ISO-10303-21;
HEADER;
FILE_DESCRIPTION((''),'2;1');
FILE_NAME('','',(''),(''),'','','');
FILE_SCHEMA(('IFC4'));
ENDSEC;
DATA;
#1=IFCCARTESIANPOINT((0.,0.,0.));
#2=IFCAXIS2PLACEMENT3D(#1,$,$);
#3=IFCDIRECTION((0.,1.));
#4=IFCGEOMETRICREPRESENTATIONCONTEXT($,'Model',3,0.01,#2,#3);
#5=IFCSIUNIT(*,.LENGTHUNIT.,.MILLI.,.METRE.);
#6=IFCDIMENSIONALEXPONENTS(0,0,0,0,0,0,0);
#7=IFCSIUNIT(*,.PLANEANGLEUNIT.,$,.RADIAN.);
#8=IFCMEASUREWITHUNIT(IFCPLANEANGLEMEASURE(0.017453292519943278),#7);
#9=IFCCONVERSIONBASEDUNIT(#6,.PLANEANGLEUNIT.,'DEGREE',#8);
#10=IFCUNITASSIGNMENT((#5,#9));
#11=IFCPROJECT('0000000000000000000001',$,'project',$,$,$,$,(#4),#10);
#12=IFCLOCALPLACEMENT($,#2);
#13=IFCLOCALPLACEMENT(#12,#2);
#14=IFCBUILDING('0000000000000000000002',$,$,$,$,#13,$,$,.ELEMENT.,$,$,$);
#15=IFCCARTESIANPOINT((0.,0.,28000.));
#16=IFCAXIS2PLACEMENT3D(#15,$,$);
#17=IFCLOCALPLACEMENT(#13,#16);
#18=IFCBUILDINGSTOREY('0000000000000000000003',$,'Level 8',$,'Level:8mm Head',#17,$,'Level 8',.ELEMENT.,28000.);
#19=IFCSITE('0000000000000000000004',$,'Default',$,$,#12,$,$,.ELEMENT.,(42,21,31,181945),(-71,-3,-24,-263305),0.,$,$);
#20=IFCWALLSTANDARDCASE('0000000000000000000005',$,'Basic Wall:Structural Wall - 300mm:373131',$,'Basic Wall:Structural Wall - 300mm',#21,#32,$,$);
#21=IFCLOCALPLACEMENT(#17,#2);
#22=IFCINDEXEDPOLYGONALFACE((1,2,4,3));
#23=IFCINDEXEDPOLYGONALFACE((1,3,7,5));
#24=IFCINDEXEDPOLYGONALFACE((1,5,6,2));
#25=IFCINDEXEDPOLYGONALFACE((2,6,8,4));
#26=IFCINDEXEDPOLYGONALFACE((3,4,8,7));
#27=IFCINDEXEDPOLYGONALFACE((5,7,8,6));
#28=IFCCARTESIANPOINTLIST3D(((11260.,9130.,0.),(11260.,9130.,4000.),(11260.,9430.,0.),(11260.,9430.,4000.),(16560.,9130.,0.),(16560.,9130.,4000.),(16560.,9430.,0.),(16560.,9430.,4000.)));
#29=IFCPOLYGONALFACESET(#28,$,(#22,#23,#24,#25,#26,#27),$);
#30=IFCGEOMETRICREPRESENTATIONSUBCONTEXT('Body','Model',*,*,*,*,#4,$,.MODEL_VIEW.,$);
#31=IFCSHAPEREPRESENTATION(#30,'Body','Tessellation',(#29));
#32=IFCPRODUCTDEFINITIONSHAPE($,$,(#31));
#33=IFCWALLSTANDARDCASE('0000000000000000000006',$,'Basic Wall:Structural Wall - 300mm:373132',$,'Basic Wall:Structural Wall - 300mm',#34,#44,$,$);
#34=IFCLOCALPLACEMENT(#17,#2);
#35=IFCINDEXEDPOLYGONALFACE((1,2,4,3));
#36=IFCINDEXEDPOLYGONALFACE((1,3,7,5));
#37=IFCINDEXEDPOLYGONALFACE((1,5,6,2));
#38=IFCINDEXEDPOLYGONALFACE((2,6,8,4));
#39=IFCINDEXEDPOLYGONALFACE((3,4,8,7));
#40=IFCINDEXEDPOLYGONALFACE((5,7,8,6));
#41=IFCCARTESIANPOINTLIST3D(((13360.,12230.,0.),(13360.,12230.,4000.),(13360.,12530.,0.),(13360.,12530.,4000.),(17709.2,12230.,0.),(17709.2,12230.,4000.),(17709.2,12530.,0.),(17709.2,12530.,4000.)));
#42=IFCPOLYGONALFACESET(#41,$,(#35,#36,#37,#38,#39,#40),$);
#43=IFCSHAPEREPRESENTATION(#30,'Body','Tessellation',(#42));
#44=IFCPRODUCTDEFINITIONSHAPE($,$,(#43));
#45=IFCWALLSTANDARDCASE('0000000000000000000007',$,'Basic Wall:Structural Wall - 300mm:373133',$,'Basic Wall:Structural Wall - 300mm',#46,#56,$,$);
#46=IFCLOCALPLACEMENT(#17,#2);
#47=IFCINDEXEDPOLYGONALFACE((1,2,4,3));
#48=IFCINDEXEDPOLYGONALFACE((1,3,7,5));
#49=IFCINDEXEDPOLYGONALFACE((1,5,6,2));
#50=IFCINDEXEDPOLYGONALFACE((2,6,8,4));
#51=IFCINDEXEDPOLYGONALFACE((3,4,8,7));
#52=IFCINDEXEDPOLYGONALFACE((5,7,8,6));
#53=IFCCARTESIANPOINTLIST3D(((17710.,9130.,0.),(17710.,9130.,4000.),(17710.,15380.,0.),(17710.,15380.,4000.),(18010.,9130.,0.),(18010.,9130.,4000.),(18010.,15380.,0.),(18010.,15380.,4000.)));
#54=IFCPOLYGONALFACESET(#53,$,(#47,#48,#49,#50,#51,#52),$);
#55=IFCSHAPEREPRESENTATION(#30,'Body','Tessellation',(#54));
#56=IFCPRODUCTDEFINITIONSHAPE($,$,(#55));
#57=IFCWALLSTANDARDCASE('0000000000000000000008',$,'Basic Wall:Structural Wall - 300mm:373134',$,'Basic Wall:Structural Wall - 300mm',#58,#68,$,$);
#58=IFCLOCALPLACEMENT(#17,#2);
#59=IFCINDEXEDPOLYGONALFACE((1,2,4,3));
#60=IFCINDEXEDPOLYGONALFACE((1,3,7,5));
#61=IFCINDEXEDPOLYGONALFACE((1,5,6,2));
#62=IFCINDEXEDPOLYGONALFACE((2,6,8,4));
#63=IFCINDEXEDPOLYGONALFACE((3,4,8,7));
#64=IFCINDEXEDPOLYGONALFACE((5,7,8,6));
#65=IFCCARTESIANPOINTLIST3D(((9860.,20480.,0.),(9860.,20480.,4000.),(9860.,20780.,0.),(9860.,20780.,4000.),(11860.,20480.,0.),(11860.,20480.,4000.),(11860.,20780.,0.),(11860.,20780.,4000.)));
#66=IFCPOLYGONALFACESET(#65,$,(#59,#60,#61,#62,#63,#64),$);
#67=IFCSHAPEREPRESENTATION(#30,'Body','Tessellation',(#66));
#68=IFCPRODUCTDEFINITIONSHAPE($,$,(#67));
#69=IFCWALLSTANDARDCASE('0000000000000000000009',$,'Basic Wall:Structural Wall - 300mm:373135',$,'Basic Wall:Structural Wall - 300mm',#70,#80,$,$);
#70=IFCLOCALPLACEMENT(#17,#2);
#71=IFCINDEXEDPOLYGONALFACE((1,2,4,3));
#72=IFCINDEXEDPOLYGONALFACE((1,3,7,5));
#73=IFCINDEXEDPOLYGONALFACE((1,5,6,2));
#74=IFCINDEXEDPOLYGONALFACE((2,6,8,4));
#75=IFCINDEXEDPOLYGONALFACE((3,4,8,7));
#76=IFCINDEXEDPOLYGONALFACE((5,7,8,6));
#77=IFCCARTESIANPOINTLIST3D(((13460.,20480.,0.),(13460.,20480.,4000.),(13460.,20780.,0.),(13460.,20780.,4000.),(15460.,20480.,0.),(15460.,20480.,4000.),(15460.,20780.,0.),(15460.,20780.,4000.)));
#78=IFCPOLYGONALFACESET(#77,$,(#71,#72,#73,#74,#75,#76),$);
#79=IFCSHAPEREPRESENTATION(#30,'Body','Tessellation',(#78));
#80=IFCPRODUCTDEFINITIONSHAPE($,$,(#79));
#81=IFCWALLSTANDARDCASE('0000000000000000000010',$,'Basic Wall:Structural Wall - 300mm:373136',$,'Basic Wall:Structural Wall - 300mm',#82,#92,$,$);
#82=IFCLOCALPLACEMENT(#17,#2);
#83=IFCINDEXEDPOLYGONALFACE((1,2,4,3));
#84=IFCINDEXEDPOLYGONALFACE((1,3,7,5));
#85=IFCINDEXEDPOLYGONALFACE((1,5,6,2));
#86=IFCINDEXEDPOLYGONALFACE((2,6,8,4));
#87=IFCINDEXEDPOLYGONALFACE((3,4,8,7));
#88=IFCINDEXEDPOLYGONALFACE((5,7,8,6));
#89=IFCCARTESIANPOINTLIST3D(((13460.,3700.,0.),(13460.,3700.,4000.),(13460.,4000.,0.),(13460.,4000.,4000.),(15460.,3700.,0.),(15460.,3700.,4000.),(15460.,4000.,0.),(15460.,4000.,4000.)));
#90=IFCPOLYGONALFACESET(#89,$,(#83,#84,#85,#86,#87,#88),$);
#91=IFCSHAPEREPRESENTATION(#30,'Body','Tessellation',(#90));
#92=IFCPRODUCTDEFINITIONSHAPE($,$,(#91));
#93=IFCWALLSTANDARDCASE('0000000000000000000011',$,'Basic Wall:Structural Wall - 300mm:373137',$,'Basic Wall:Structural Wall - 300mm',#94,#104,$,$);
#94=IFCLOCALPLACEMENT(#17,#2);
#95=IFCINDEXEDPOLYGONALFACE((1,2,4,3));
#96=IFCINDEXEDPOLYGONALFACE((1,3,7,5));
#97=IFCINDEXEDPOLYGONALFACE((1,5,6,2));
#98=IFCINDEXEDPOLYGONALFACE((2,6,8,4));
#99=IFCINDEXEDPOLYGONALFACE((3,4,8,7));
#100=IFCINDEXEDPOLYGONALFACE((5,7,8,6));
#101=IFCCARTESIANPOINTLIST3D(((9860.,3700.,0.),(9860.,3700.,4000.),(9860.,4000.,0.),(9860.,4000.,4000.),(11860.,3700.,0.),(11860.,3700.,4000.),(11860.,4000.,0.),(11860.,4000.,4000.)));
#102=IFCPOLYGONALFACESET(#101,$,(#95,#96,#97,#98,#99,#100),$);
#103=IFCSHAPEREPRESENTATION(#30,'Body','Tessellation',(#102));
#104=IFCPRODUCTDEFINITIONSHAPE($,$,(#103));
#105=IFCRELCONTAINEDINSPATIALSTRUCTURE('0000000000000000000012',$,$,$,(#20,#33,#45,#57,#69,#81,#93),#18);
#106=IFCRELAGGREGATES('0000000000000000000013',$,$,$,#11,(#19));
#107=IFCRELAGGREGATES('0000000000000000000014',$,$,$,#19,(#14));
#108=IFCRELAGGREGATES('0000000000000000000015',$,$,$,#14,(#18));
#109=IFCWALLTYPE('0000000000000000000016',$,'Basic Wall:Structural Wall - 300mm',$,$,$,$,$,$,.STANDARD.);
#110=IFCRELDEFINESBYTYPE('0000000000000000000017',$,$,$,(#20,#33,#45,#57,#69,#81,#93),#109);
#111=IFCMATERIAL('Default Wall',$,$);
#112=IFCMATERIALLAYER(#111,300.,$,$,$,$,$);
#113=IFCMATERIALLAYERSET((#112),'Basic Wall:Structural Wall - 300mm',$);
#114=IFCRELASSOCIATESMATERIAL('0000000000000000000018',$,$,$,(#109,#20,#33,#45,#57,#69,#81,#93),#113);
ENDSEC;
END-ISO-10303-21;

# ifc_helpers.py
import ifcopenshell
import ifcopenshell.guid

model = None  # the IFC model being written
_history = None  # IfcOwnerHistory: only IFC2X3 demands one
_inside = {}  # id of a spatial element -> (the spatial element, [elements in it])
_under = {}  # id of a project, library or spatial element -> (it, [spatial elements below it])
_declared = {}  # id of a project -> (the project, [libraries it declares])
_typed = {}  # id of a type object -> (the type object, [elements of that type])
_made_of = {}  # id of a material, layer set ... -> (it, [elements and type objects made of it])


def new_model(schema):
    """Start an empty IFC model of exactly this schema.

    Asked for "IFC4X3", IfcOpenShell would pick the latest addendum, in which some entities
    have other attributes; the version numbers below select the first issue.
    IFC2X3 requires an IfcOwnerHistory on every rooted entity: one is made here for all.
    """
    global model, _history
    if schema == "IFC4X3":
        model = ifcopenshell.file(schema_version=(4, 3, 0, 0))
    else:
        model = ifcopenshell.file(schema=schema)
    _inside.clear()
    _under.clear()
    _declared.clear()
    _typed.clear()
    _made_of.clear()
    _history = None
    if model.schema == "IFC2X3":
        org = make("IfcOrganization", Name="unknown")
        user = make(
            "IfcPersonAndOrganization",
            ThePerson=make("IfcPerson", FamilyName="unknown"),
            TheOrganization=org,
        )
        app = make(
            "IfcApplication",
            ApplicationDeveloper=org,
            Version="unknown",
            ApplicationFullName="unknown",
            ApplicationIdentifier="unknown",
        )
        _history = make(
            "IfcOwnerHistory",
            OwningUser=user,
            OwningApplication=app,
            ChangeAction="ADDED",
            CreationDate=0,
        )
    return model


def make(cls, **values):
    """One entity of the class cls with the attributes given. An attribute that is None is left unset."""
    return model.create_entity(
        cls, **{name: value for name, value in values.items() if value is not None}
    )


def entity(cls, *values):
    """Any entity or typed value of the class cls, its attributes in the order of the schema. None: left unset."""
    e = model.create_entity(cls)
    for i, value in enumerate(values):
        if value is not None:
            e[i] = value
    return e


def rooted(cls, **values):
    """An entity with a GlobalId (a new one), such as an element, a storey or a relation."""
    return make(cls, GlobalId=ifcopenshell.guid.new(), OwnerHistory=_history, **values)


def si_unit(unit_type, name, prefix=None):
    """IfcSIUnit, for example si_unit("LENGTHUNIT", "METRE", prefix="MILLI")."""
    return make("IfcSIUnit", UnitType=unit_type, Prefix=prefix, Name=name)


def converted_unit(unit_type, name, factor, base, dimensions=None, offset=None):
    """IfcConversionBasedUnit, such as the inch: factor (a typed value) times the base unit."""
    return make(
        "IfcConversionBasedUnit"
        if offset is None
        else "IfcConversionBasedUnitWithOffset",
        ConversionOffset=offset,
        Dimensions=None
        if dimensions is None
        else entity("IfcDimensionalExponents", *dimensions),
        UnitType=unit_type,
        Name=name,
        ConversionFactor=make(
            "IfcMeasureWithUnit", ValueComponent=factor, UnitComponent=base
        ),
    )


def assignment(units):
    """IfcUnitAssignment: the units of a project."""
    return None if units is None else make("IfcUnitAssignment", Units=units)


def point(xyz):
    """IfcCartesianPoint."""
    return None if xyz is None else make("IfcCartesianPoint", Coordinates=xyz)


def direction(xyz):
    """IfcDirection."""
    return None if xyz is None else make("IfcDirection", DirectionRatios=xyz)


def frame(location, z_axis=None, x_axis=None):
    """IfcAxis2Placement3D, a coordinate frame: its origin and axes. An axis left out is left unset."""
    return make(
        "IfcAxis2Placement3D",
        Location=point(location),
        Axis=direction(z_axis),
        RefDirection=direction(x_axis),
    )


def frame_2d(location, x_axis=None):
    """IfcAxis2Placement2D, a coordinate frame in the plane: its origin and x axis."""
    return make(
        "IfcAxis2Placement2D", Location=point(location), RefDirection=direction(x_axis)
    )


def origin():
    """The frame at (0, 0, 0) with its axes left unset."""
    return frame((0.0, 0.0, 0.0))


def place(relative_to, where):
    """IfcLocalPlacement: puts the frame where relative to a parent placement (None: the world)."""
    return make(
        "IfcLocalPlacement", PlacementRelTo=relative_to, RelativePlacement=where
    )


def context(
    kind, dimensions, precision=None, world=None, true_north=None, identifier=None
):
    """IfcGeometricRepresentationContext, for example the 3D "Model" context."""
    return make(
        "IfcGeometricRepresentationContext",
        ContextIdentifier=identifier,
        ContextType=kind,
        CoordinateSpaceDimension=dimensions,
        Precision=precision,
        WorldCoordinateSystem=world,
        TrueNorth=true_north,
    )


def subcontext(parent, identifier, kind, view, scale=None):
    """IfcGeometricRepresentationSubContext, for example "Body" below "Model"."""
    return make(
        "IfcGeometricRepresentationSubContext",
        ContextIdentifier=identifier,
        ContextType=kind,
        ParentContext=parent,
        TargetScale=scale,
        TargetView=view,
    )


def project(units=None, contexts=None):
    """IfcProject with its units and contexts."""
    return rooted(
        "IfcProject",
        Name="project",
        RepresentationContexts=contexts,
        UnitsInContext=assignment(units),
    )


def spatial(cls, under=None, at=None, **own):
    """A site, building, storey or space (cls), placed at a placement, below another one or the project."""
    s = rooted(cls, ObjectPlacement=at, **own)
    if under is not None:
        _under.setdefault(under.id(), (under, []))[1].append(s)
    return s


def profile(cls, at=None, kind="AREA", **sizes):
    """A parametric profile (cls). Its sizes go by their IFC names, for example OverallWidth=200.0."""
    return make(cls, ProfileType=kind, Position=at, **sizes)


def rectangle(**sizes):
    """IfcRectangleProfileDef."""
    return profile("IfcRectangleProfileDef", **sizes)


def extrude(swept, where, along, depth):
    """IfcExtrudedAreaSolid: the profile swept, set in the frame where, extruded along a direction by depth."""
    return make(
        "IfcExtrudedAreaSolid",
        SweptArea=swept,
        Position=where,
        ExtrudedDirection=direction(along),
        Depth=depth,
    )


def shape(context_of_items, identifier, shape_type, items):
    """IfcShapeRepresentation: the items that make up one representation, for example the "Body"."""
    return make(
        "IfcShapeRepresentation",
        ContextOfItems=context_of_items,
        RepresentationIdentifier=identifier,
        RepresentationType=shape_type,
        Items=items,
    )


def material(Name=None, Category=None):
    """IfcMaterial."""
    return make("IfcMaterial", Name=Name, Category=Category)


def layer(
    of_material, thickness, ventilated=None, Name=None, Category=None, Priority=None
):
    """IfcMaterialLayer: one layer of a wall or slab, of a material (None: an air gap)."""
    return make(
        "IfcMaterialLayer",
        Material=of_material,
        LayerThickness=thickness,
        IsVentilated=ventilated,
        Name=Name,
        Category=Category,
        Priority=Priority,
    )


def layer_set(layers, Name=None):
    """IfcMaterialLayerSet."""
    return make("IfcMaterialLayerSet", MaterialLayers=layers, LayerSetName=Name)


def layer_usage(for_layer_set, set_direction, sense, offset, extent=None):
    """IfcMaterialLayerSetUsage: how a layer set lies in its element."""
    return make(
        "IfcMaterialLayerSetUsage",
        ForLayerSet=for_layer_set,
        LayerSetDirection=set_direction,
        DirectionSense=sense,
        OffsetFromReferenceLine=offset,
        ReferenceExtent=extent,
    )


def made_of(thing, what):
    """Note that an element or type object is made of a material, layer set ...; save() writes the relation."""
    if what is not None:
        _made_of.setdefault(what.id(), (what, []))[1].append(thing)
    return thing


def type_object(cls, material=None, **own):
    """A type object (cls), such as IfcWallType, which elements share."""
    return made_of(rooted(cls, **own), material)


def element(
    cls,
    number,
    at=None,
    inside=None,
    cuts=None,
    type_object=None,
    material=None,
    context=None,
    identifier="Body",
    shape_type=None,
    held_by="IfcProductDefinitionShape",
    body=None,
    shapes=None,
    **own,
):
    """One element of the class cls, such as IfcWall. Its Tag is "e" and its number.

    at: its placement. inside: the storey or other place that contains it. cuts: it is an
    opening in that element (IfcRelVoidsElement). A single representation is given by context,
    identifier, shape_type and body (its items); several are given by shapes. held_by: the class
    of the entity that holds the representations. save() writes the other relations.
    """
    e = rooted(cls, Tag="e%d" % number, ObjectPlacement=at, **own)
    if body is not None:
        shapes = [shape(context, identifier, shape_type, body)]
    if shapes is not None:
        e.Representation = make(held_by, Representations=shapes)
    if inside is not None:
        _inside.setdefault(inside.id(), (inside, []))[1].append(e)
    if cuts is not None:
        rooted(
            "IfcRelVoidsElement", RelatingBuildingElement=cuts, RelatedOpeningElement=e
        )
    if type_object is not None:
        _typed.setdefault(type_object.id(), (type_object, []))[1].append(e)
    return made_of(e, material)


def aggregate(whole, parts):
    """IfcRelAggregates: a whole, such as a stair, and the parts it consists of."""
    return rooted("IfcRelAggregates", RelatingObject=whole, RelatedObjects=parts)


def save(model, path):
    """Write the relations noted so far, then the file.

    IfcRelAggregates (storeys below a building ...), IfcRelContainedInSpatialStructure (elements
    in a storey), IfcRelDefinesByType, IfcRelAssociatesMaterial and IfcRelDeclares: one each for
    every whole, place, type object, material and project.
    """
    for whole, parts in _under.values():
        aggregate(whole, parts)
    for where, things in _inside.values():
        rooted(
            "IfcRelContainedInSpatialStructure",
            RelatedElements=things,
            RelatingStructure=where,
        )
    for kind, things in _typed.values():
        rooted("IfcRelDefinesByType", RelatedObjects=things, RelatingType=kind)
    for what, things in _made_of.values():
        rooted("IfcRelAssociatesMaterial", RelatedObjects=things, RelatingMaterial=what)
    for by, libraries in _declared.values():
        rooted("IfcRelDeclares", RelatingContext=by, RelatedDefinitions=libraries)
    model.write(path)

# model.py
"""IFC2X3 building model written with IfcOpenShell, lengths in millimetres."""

from ifc_helpers import new_model, entity, si_unit, converted_unit, direction, frame, frame_2d, origin, place, context, subcontext, project, spatial, rectangle, extrude, material, layer, layer_set, layer_usage, type_object, element, save


model = new_model("IFC2X3")

# Units and contexts
model_context = context("Model", 3, precision=0.01, world=origin(), true_north=direction((0.0, 1.0)))
body_context = subcontext(model_context, "Body", "Model", "MODEL_VIEW")
ifc_project = project(units=[si_unit("LENGTHUNIT", "METRE", prefix="MILLI"), converted_unit("PLANEANGLEUNIT", "DEGREE", entity("IfcPlaneAngleMeasure", 0.017453292519943278), si_unit("PLANEANGLEUNIT", "RADIAN"), dimensions=[0, 0, 0, 0, 0, 0, 0])], contexts=[model_context])

# Site, building, storey
site_placement = place(None, origin())
site = spatial("IfcSite", under=ifc_project, at=site_placement, Name="Default", CompositionType="ELEMENT", RefLatitude=(42, 21, 31, 181945), RefLongitude=(-71, -3, -24, -263305), RefElevation=0.0)
building_placement = place(site_placement, origin())
building = spatial("IfcBuilding", under=site, at=building_placement, CompositionType="ELEMENT")
storey_placement = place(building_placement, frame((0.0, 0.0, 28000.0)))
storey = spatial("IfcBuildingStorey", under=building, at=storey_placement, Name="Level 8", ObjectType="Level:8mm Head", LongName="Level 8", CompositionType="ELEMENT", Elevation=28000.0)

# Walls
ifc_material_1 = material(Name="Default Wall")
ifc_layer_1 = layer(ifc_material_1, 300.0)
ifc_layer_set_1 = layer_set([ifc_layer_1], Name="Basic Wall:Structural Wall - 300mm")
wall_type = type_object("IfcWallType", Name="Basic Wall:Structural Wall - 300mm", PredefinedType="STANDARD", material=ifc_layer_set_1)
ifc_layer_usage_1 = layer_usage(ifc_layer_set_1, "AXIS2", "NEGATIVE", 150.0)
wall_1_placement = place(storey_placement, frame((11260.0, 9280.0, 0.0)))
element("IfcWallStandardCase", 1, at=wall_1_placement, inside=storey, type_object=wall_type, material=ifc_layer_usage_1, Name="Basic Wall:Structural Wall - 300mm:373131", ObjectType="Basic Wall:Structural Wall - 300mm", context=body_context, shape_type="SweptSolid", body=[
    extrude(rectangle(XDim=5300.0, YDim=300.0, at=frame_2d((2650.0, 0.0), x_axis=(-1.0, 0.0))), origin(), (0.0, 0.0, 1.0), 4000.0),
])
ifc_layer_usage_2 = layer_usage(ifc_layer_set_1, "AXIS2", "NEGATIVE", 150.0)
wall_2_placement = place(storey_placement, frame((13360.0, 12380.0, 0.0)))
element("IfcWallStandardCase", 2, at=wall_2_placement, inside=storey, type_object=wall_type, material=ifc_layer_usage_2, Name="Basic Wall:Structural Wall - 300mm:373132", ObjectType="Basic Wall:Structural Wall - 300mm", context=body_context, shape_type="SweptSolid", body=[
    extrude(rectangle(XDim=4349.2, YDim=300.0, at=frame_2d((2174.6, 0.0), x_axis=(-1.0, 0.0))), origin(), (0.0, 0.0, 1.0), 4000.0),
])
ifc_layer_usage_3 = layer_usage(ifc_layer_set_1, "AXIS2", "NEGATIVE", 150.0)
wall_3_placement = place(storey_placement, frame((17860.0, 15380.0, 0.0), z_axis=(0.0, 0.0, 1.0), x_axis=(0.0, -1.0, 0.0)))
element("IfcWallStandardCase", 3, at=wall_3_placement, inside=storey, type_object=wall_type, material=ifc_layer_usage_3, Name="Basic Wall:Structural Wall - 300mm:373133", ObjectType="Basic Wall:Structural Wall - 300mm", context=body_context, shape_type="SweptSolid", body=[
    extrude(rectangle(XDim=6250.0, YDim=300.0, at=frame_2d((3125.0, 0.0), x_axis=(-1.0, 0.0))), origin(), (0.0, 0.0, 1.0), 4000.0),
])
ifc_layer_usage_4 = layer_usage(ifc_layer_set_1, "AXIS2", "NEGATIVE", 150.0)
wall_4_placement = place(storey_placement, frame((9860.0, 20630.0, 0.0)))
element("IfcWallStandardCase", 4, at=wall_4_placement, inside=storey, type_object=wall_type, material=ifc_layer_usage_4, Name="Basic Wall:Structural Wall - 300mm:373134", ObjectType="Basic Wall:Structural Wall - 300mm", context=body_context, shape_type="SweptSolid", body=[
    extrude(rectangle(XDim=2000.0, YDim=300.0, at=frame_2d((1000.0, 0.0), x_axis=(-1.0, 0.0))), origin(), (0.0, 0.0, 1.0), 4000.0),
])
ifc_layer_usage_5 = layer_usage(ifc_layer_set_1, "AXIS2", "NEGATIVE", 150.0)
wall_5_placement = place(storey_placement, frame((13460.0, 20630.0, 0.0)))
element("IfcWallStandardCase", 5, at=wall_5_placement, inside=storey, type_object=wall_type, material=ifc_layer_usage_5, Name="Basic Wall:Structural Wall - 300mm:373135", ObjectType="Basic Wall:Structural Wall - 300mm", context=body_context, shape_type="SweptSolid", body=[
    extrude(rectangle(XDim=2000.0, YDim=300.0, at=frame_2d((1000.0, 0.0), x_axis=(-1.0, 0.0))), origin(), (0.0, 0.0, 1.0), 4000.0),
])
ifc_layer_usage_6 = layer_usage(ifc_layer_set_1, "AXIS2", "NEGATIVE", 150.0)
wall_6_placement = place(storey_placement, frame((13460.0, 3850.0, 0.0)))
element("IfcWallStandardCase", 6, at=wall_6_placement, inside=storey, type_object=wall_type, material=ifc_layer_usage_6, Name="Basic Wall:Structural Wall - 300mm:373136", ObjectType="Basic Wall:Structural Wall - 300mm", context=body_context, shape_type="SweptSolid", body=[
    extrude(rectangle(XDim=2000.0, YDim=300.0, at=frame_2d((1000.0, 0.0), x_axis=(-1.0, 0.0))), origin(), (0.0, 0.0, 1.0), 4000.0),
])
ifc_layer_usage_7 = layer_usage(ifc_layer_set_1, "AXIS2", "NEGATIVE", 150.0)
wall_7_placement = place(storey_placement, frame((9860.0, 3850.0, 0.0)))
element("IfcWallStandardCase", 7, at=wall_7_placement, inside=storey, type_object=wall_type, material=ifc_layer_usage_7, Name="Basic Wall:Structural Wall - 300mm:373137", ObjectType="Basic Wall:Structural Wall - 300mm", context=body_context, shape_type="SweptSolid", body=[
    extrude(rectangle(XDim=2000.0, YDim=300.0, at=frame_2d((1000.0, 0.0), x_axis=(-1.0, 0.0))), origin(), (0.0, 0.0, 1.0), 4000.0),
])

save(model, "model.ifc")
